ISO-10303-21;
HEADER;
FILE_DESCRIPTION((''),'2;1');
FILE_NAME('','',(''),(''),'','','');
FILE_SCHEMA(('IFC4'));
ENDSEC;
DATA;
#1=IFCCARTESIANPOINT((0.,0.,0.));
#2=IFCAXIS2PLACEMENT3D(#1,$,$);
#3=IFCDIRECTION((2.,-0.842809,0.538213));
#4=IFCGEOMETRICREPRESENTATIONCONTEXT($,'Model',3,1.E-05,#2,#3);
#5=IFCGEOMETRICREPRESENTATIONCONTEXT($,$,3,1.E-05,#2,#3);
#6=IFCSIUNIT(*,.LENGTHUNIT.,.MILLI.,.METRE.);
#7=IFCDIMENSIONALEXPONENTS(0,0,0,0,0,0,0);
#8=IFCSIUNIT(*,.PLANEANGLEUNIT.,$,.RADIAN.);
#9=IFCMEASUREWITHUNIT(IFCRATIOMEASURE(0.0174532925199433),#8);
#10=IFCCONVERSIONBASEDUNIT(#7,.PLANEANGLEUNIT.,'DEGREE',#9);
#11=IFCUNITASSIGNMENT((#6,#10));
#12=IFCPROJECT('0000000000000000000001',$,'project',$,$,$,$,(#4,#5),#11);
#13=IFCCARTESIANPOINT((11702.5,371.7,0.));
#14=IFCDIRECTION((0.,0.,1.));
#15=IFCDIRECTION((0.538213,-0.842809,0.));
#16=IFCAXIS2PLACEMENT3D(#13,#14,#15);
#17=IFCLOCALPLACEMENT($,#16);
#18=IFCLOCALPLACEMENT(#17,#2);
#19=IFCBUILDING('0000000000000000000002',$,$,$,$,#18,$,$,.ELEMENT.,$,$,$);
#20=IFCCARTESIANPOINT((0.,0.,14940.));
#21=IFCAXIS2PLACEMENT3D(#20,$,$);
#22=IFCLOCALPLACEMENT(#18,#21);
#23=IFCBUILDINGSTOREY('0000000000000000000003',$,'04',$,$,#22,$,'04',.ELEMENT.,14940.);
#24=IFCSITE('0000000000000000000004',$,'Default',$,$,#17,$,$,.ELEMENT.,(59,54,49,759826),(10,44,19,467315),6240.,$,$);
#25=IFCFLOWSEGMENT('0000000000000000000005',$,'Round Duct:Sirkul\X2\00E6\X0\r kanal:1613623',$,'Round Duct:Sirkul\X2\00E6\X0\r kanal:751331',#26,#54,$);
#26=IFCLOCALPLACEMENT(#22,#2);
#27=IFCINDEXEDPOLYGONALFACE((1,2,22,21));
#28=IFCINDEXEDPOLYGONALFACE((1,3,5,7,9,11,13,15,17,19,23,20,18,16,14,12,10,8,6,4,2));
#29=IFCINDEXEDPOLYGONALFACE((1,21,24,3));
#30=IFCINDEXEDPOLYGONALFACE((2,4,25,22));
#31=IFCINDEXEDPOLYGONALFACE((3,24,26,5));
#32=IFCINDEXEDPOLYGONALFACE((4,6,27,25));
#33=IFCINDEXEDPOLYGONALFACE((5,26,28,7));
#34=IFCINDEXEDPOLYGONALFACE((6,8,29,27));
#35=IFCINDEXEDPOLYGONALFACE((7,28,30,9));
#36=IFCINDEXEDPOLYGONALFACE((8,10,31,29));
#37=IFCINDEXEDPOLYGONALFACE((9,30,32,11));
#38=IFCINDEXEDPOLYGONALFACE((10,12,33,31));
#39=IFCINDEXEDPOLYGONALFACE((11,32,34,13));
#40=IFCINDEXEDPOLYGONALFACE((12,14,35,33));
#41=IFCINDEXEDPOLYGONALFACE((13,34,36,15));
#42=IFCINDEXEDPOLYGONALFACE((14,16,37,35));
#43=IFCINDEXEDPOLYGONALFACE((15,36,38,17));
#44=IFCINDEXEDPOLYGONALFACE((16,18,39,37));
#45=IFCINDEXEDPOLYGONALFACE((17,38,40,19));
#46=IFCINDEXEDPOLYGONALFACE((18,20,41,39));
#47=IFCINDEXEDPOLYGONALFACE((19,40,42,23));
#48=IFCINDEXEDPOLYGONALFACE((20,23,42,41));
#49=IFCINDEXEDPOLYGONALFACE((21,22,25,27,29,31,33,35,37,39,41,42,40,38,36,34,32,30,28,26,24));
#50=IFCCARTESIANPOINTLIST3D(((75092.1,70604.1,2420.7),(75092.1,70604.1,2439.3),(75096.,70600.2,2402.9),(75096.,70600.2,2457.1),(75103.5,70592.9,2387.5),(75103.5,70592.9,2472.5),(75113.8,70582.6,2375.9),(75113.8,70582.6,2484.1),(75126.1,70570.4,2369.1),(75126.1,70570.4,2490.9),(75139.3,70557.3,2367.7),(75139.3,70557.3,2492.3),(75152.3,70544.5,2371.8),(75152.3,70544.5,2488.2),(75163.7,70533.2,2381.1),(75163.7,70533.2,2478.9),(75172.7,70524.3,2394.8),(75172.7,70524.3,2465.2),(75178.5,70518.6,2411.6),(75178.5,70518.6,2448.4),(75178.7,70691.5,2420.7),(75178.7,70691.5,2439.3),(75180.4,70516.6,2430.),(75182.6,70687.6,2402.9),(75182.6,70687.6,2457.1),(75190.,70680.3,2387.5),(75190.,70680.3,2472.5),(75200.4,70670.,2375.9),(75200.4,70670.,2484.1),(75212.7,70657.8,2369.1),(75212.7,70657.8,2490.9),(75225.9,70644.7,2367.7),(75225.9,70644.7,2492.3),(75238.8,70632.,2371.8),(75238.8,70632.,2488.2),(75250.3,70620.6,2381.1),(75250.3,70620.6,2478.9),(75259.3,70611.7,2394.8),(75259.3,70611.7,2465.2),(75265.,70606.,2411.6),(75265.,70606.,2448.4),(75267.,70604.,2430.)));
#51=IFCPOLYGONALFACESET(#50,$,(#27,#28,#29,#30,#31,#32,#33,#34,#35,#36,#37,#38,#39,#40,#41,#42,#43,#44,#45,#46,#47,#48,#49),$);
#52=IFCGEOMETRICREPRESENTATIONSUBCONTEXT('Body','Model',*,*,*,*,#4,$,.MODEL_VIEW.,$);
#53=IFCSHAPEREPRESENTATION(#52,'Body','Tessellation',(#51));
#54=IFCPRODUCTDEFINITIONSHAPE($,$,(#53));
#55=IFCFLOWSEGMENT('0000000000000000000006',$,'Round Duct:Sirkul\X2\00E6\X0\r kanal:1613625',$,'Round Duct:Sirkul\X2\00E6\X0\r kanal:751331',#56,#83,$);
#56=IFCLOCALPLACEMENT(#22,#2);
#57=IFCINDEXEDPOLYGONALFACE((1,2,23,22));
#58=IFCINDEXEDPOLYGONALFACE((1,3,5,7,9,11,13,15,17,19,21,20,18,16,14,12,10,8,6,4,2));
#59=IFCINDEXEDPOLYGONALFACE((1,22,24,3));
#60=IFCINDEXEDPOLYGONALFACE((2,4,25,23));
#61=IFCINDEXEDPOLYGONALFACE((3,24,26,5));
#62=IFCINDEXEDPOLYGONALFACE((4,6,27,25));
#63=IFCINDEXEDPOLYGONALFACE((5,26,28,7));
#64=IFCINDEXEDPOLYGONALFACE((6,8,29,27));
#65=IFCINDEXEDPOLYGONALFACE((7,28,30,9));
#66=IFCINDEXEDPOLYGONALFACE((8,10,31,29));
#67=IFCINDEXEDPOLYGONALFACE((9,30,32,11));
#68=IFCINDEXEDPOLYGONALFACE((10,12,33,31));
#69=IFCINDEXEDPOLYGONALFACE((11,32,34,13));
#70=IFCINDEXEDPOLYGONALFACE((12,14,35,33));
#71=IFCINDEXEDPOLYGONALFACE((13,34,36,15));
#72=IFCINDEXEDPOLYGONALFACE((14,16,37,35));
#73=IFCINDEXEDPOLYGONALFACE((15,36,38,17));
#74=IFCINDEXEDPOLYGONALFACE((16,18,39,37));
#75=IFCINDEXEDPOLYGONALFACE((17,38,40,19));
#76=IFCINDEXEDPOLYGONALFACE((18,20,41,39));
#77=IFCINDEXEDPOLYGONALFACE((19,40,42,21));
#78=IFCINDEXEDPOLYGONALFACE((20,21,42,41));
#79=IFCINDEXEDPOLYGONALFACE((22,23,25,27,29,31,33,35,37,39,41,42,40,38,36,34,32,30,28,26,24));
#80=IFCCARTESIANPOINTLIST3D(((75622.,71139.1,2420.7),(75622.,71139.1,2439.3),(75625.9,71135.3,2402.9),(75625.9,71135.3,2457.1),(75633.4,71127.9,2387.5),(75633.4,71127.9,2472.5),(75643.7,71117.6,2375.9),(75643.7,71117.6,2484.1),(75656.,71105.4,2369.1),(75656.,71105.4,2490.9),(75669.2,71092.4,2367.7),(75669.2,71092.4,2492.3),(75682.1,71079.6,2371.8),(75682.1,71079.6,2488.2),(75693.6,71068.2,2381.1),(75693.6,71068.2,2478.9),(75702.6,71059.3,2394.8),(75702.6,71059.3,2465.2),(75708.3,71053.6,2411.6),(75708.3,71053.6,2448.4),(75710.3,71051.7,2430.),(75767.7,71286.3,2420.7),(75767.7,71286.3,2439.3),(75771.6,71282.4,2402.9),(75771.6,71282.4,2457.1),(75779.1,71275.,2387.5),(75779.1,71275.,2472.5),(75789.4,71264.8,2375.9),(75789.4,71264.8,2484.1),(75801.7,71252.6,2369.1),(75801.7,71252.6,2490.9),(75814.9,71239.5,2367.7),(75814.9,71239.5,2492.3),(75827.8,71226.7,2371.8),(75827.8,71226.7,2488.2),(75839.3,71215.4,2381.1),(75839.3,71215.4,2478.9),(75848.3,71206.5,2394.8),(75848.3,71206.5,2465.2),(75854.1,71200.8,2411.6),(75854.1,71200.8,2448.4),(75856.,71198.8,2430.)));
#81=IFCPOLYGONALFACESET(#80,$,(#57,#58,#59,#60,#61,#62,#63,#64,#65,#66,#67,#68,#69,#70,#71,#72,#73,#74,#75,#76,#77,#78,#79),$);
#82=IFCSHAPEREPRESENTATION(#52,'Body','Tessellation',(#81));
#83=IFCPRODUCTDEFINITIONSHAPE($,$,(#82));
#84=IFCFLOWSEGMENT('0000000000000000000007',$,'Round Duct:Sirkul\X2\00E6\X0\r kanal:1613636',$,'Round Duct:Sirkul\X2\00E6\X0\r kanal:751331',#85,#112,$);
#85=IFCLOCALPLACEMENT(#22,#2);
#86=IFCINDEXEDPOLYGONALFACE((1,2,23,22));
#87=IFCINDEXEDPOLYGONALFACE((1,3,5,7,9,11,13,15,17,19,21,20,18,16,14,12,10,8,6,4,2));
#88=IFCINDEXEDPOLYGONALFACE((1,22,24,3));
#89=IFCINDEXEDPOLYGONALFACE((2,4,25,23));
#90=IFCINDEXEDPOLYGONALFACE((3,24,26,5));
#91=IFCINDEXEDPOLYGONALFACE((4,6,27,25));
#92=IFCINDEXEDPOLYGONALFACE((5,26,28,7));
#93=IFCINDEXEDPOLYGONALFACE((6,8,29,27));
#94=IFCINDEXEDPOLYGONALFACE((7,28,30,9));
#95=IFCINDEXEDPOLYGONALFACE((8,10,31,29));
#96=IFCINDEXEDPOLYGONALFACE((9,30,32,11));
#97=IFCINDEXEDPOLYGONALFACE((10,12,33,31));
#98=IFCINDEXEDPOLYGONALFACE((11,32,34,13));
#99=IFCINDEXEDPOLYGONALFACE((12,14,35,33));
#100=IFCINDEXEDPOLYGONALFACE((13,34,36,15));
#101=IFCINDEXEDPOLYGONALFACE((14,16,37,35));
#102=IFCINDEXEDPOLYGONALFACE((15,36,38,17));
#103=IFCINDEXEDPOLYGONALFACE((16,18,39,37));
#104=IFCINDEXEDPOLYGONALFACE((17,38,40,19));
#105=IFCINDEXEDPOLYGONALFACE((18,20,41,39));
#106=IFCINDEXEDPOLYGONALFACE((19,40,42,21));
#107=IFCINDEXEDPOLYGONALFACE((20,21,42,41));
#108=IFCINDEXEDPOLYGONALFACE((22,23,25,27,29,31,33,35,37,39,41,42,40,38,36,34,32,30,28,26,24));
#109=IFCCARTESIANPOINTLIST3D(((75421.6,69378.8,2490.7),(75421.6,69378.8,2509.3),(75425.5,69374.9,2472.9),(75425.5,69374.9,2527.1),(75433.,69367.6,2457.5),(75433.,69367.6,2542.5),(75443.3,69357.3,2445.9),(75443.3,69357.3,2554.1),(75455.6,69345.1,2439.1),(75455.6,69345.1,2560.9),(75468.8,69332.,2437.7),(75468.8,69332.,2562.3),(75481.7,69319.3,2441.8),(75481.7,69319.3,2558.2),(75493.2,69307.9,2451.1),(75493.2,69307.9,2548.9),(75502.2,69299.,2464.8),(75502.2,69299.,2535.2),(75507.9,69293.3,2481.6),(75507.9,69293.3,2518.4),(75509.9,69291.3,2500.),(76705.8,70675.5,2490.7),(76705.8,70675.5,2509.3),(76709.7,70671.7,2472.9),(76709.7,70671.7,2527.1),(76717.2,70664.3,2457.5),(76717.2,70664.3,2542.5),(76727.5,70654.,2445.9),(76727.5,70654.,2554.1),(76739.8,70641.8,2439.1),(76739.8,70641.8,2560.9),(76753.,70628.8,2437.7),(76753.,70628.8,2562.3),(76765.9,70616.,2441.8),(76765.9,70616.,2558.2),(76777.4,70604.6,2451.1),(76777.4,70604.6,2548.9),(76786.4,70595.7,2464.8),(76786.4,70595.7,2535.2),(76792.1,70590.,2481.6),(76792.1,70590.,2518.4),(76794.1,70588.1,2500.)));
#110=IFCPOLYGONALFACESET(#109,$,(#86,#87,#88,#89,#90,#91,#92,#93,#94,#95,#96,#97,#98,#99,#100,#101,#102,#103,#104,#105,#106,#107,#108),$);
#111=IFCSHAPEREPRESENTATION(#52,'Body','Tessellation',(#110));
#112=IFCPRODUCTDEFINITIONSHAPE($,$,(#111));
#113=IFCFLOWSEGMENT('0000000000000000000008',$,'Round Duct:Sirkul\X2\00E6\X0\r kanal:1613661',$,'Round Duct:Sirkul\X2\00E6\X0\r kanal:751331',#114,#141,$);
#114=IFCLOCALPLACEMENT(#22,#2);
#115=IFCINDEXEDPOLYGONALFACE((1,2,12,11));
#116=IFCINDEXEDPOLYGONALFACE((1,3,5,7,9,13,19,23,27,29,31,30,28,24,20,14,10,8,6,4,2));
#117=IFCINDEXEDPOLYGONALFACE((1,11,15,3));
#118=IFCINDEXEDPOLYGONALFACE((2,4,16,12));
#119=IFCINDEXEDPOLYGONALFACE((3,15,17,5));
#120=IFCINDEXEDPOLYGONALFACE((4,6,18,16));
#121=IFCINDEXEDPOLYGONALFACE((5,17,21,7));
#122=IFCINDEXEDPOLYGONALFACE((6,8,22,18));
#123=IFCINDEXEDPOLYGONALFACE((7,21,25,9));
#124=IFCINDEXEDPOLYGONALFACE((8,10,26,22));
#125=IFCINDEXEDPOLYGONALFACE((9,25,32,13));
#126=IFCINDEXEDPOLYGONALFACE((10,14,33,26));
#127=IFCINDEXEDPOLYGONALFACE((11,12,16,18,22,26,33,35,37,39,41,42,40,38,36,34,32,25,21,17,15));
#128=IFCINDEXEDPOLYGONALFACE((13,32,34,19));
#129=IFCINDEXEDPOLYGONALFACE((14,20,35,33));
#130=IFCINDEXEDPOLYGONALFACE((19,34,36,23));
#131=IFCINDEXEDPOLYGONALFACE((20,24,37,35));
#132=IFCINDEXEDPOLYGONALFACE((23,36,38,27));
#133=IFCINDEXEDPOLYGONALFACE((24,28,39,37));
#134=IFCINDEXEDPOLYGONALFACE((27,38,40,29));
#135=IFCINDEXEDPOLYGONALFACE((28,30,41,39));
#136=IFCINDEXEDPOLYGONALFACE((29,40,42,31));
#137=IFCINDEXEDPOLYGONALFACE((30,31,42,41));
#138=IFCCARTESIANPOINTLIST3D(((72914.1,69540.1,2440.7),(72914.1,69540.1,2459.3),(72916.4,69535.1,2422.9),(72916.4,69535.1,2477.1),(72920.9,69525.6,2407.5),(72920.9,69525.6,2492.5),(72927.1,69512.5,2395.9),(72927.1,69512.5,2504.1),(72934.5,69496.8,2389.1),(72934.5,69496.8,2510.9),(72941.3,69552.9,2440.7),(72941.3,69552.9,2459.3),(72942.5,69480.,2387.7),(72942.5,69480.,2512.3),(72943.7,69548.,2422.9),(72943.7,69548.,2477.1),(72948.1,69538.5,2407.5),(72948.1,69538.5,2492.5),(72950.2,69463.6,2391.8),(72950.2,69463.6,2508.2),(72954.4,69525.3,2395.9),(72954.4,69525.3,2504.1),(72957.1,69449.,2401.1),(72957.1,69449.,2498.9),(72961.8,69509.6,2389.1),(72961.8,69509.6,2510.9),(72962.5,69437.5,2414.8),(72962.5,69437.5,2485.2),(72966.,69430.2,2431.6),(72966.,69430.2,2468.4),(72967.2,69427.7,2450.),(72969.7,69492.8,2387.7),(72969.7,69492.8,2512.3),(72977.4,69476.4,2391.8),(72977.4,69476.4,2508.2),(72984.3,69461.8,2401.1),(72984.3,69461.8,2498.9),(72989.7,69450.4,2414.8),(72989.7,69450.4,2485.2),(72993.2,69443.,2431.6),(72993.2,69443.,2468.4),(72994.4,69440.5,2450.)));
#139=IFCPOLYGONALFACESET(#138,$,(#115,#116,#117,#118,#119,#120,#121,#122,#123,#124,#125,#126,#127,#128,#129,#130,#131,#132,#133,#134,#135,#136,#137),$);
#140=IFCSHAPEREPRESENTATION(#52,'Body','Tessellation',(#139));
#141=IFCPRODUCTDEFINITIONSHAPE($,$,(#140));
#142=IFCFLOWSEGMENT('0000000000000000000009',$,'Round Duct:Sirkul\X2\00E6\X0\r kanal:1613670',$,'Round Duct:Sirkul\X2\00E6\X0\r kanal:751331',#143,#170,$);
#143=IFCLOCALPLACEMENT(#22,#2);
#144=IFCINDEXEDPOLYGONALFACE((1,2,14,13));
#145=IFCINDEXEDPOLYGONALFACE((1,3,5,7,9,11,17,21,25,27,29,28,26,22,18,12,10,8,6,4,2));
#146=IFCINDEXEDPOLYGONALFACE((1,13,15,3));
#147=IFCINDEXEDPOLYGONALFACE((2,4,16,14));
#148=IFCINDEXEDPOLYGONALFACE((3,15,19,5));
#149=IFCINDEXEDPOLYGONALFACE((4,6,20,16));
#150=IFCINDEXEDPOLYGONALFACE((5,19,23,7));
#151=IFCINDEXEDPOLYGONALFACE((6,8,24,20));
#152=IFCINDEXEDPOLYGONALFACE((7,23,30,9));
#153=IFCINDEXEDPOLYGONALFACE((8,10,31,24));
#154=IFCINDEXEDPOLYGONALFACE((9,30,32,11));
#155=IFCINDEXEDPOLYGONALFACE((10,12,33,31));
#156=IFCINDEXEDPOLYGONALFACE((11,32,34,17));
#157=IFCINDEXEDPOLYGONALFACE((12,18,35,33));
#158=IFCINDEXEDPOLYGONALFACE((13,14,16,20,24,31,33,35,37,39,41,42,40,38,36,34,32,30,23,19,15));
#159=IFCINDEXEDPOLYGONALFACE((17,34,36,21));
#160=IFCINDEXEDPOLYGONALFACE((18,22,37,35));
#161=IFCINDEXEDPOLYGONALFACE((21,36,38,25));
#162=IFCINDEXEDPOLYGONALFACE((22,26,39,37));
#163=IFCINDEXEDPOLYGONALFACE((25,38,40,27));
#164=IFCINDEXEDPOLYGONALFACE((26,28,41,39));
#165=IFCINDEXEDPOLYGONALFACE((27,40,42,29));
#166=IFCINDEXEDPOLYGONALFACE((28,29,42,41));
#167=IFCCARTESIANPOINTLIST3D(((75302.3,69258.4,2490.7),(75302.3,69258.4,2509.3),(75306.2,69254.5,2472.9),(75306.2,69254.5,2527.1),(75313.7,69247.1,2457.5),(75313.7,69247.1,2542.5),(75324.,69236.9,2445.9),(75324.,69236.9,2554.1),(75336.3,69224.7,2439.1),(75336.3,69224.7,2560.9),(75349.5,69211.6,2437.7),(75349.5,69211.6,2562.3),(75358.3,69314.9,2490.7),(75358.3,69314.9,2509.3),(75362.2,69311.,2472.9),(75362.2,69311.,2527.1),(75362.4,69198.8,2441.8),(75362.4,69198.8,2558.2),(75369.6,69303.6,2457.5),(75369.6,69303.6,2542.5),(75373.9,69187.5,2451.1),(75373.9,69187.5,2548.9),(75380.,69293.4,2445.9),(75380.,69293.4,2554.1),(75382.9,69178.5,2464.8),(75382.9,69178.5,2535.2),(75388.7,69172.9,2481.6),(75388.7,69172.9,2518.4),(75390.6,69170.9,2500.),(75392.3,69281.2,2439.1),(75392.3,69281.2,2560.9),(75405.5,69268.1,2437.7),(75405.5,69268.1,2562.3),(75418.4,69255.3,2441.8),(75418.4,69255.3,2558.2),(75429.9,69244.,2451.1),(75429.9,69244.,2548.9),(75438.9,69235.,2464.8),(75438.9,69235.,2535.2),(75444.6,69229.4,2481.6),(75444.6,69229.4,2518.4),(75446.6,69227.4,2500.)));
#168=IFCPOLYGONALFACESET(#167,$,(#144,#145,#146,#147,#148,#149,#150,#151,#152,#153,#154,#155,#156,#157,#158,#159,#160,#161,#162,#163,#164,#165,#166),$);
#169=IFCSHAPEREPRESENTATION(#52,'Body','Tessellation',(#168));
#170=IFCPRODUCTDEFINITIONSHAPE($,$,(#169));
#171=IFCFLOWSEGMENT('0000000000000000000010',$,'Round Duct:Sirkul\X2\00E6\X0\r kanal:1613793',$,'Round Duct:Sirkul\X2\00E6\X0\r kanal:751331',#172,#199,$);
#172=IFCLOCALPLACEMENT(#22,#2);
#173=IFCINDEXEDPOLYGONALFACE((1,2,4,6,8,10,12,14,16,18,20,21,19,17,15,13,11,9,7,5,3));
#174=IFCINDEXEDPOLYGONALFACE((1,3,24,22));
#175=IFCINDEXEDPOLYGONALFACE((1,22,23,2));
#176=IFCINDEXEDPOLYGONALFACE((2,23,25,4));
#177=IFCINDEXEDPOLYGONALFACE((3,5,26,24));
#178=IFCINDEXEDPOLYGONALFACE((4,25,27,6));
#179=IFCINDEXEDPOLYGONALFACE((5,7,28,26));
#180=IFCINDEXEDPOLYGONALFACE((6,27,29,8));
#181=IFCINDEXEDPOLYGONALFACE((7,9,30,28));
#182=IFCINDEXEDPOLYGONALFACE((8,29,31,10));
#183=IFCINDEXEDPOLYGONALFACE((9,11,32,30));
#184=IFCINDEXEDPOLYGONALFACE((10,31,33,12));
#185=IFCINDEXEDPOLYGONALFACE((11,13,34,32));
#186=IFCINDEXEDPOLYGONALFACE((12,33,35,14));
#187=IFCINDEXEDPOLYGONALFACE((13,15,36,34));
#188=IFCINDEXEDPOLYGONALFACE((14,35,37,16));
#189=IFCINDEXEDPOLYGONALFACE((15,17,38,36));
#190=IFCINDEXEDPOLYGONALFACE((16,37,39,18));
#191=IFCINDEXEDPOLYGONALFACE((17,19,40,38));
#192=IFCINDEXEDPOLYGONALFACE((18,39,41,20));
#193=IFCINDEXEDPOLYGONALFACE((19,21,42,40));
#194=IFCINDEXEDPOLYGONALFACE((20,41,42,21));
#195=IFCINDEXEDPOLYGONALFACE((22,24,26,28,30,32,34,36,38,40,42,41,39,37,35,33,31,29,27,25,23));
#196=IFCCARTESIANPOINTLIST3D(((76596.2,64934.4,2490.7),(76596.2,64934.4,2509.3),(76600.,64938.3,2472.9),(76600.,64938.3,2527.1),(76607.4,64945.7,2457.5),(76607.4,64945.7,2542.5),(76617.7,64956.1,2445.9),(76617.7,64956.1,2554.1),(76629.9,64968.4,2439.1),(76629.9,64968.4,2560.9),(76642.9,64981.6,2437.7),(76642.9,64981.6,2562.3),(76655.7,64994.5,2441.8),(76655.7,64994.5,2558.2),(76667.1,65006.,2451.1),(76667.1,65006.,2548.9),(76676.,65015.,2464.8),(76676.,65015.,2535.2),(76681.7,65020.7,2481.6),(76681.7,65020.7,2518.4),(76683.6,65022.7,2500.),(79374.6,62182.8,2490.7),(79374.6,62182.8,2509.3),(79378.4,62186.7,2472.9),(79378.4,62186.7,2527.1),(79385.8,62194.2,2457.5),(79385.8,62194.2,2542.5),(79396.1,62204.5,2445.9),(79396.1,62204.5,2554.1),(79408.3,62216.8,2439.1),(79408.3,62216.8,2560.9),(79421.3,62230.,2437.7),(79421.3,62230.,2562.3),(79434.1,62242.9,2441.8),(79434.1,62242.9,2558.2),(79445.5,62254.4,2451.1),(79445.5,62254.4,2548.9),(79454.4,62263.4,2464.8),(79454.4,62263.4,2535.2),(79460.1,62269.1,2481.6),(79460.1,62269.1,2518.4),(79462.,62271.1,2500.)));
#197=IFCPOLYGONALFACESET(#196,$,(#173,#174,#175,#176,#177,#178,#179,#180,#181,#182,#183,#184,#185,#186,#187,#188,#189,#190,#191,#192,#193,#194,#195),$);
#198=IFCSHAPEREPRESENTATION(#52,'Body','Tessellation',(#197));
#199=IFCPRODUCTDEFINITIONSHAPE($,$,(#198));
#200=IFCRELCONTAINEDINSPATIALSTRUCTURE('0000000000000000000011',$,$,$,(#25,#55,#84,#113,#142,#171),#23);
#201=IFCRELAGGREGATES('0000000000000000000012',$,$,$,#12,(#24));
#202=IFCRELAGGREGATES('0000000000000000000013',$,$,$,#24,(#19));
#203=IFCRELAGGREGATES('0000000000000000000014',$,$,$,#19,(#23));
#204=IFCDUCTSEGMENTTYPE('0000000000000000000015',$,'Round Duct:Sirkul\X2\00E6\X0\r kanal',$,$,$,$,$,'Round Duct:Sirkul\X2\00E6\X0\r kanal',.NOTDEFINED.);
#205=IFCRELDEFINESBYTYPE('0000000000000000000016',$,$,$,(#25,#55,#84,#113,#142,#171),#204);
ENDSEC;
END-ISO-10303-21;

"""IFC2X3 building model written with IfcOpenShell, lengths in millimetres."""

from ifc_helpers import new_model, entity, si_unit, converted_unit, direction, frame, frame_2d, origin, origin_2d_with_axis, place, context, subcontext, project, spatial, circle, extrude, type_object, element, save


model = new_model("IFC2X3")

# Units and contexts
model_context = context("Model", 3, precision=1e-05, world=origin(), true_north=direction((2.0, -0.842809, 0.538213)))
context_of_model = context(None, 3, precision=1e-05, world=origin(), true_north=direction((2.0, -0.842809, 0.538213)))
body_context = subcontext(model_context, "Body", "Model", "MODEL_VIEW")
ifc_project = project(units=[si_unit("LENGTHUNIT", "METRE", prefix="MILLI"), converted_unit("PLANEANGLEUNIT", "DEGREE", entity("IfcRatioMeasure", 0.0174532925199433), si_unit("PLANEANGLEUNIT", "RADIAN"), dimensions=[0, 0, 0, 0, 0, 0, 0])], contexts=[model_context, context_of_model])

# Site, building, storey
site_placement = place(None, frame((11702.5, 371.7, 0.0), z_axis=(0.0, 0.0, 1.0), x_axis=(0.538213, -0.842809, 0.0)))
site = spatial("IfcSite", under=ifc_project, at=site_placement, Name="Default", CompositionType="ELEMENT", RefLatitude=(59, 54, 49, 759826), RefLongitude=(10, 44, 19, 467315), RefElevation=6240.0)
building_placement = place(site_placement, origin())
building = spatial("IfcBuilding", under=site, at=building_placement, CompositionType="ELEMENT")
storey_placement = place(building_placement, frame((0.0, 0.0, 14940.0)))
storey = spatial("IfcBuildingStorey", under=building, at=storey_placement, Name="04", LongName="04", CompositionType="ELEMENT", Elevation=14940.0)

# Flow segments
duct_segment_type = type_object("IfcDuctSegmentType", Name="Round Duct:Sirkulær kanal", ElementType="Round Duct:Sirkulær kanal", PredefinedType="NOTDEFINED")
flow_segment_1_placement = place(storey_placement, origin())
element("IfcFlowSegment", 1, at=flow_segment_1_placement, inside=storey, type_object=duct_segment_type, Name="Round Duct:Sirkulær kanal:1613623", ObjectType="Round Duct:Sirkulær kanal:751331", context=body_context, shape_type="SweptSolid", body=[
    extrude(circle(Radius=62.5, at=origin_2d_with_axis()), frame((75136.0, 70560.6, 2430.0), z_axis=(0.703669, 0.710528, 0.0), x_axis=(0.710528, -0.703669, 0.0)), (0.0, 0.0, 1.0), 123.0),
])
flow_segment_2_placement = place(storey_placement, origin())
element("IfcFlowSegment", 2, at=flow_segment_2_placement, inside=storey, type_object=duct_segment_type, Name="Round Duct:Sirkulær kanal:1613625", ObjectType="Round Duct:Sirkulær kanal:751331", context=body_context, shape_type="SweptSolid", body=[
    extrude(circle(Radius=62.5, at=origin_2d_with_axis()), frame((75665.9, 71095.7, 2430.0), z_axis=(0.703669, 0.710528, 0.0), x_axis=(0.710528, -0.703669, 0.0)), (0.0, 0.0, 1.0), 207.1),
])
flow_segment_3_placement = place(storey_placement, origin())
element("IfcFlowSegment", 3, at=flow_segment_3_placement, inside=storey, type_object=duct_segment_type, Name="Round Duct:Sirkulær kanal:1613636", ObjectType="Round Duct:Sirkulær kanal:751331", context=body_context, shape_type="SweptSolid", body=[
    extrude(circle(Radius=62.5, at=origin_2d_with_axis()), frame((75465.5, 69335.3, 2500.0), z_axis=(0.703669, 0.710528, 0.0), x_axis=(0.710528, -0.703669, 0.0)), (0.0, 0.0, 1.0), 1825.0),
])
flow_segment_4_placement = place(storey_placement, origin())
element("IfcFlowSegment", 4, at=flow_segment_4_placement, inside=storey, type_object=duct_segment_type, Name="Round Duct:Sirkulær kanal:1613661", ObjectType="Round Duct:Sirkulær kanal:751331", context=body_context, shape_type="SweptSolid", body=[
    extrude(circle(Radius=62.5, at=frame_2d((0.0, 0.0), x_axis=(1.0, 0.0))), frame((72940.5, 69484.2, 2450.0), z_axis=(0.904247, 0.427009, 0.0), x_axis=(0.427009, -0.904247, 0.0)), (0.0, 0.0, 1.0), 30.1),
])
flow_segment_5_placement = place(storey_placement, origin())
element("IfcFlowSegment", 5, at=flow_segment_5_placement, inside=storey, type_object=duct_segment_type, Name="Round Duct:Sirkulær kanal:1613670", ObjectType="Round Duct:Sirkulær kanal:751331", context=body_context, shape_type="SweptSolid", body=[
    extrude(circle(Radius=62.5, at=origin_2d_with_axis()), frame((75346.2, 69214.9, 2500.0), z_axis=(0.703669, 0.710528, 0.0), x_axis=(0.710528, -0.703669, 0.0)), (0.0, 0.0, 1.0), 79.5),
])
flow_segment_6_placement = place(storey_placement, origin())
element("IfcFlowSegment", 6, at=flow_segment_6_placement, inside=storey, type_object=duct_segment_type, Name="Round Duct:Sirkulær kanal:1613793", ObjectType="Round Duct:Sirkulær kanal:751331", context=body_context, shape_type="SweptSolid", body=[
    extrude(circle(Radius=62.5, at=origin_2d_with_axis()), frame((76639.6, 64978.3, 2500.0), z_axis=(0.710528, -0.703669, 0.0), x_axis=(0.703669, 0.710528, 0.0)), (0.0, 0.0, 1.0), 3910.3),
])

save(model, "model.ifc")
